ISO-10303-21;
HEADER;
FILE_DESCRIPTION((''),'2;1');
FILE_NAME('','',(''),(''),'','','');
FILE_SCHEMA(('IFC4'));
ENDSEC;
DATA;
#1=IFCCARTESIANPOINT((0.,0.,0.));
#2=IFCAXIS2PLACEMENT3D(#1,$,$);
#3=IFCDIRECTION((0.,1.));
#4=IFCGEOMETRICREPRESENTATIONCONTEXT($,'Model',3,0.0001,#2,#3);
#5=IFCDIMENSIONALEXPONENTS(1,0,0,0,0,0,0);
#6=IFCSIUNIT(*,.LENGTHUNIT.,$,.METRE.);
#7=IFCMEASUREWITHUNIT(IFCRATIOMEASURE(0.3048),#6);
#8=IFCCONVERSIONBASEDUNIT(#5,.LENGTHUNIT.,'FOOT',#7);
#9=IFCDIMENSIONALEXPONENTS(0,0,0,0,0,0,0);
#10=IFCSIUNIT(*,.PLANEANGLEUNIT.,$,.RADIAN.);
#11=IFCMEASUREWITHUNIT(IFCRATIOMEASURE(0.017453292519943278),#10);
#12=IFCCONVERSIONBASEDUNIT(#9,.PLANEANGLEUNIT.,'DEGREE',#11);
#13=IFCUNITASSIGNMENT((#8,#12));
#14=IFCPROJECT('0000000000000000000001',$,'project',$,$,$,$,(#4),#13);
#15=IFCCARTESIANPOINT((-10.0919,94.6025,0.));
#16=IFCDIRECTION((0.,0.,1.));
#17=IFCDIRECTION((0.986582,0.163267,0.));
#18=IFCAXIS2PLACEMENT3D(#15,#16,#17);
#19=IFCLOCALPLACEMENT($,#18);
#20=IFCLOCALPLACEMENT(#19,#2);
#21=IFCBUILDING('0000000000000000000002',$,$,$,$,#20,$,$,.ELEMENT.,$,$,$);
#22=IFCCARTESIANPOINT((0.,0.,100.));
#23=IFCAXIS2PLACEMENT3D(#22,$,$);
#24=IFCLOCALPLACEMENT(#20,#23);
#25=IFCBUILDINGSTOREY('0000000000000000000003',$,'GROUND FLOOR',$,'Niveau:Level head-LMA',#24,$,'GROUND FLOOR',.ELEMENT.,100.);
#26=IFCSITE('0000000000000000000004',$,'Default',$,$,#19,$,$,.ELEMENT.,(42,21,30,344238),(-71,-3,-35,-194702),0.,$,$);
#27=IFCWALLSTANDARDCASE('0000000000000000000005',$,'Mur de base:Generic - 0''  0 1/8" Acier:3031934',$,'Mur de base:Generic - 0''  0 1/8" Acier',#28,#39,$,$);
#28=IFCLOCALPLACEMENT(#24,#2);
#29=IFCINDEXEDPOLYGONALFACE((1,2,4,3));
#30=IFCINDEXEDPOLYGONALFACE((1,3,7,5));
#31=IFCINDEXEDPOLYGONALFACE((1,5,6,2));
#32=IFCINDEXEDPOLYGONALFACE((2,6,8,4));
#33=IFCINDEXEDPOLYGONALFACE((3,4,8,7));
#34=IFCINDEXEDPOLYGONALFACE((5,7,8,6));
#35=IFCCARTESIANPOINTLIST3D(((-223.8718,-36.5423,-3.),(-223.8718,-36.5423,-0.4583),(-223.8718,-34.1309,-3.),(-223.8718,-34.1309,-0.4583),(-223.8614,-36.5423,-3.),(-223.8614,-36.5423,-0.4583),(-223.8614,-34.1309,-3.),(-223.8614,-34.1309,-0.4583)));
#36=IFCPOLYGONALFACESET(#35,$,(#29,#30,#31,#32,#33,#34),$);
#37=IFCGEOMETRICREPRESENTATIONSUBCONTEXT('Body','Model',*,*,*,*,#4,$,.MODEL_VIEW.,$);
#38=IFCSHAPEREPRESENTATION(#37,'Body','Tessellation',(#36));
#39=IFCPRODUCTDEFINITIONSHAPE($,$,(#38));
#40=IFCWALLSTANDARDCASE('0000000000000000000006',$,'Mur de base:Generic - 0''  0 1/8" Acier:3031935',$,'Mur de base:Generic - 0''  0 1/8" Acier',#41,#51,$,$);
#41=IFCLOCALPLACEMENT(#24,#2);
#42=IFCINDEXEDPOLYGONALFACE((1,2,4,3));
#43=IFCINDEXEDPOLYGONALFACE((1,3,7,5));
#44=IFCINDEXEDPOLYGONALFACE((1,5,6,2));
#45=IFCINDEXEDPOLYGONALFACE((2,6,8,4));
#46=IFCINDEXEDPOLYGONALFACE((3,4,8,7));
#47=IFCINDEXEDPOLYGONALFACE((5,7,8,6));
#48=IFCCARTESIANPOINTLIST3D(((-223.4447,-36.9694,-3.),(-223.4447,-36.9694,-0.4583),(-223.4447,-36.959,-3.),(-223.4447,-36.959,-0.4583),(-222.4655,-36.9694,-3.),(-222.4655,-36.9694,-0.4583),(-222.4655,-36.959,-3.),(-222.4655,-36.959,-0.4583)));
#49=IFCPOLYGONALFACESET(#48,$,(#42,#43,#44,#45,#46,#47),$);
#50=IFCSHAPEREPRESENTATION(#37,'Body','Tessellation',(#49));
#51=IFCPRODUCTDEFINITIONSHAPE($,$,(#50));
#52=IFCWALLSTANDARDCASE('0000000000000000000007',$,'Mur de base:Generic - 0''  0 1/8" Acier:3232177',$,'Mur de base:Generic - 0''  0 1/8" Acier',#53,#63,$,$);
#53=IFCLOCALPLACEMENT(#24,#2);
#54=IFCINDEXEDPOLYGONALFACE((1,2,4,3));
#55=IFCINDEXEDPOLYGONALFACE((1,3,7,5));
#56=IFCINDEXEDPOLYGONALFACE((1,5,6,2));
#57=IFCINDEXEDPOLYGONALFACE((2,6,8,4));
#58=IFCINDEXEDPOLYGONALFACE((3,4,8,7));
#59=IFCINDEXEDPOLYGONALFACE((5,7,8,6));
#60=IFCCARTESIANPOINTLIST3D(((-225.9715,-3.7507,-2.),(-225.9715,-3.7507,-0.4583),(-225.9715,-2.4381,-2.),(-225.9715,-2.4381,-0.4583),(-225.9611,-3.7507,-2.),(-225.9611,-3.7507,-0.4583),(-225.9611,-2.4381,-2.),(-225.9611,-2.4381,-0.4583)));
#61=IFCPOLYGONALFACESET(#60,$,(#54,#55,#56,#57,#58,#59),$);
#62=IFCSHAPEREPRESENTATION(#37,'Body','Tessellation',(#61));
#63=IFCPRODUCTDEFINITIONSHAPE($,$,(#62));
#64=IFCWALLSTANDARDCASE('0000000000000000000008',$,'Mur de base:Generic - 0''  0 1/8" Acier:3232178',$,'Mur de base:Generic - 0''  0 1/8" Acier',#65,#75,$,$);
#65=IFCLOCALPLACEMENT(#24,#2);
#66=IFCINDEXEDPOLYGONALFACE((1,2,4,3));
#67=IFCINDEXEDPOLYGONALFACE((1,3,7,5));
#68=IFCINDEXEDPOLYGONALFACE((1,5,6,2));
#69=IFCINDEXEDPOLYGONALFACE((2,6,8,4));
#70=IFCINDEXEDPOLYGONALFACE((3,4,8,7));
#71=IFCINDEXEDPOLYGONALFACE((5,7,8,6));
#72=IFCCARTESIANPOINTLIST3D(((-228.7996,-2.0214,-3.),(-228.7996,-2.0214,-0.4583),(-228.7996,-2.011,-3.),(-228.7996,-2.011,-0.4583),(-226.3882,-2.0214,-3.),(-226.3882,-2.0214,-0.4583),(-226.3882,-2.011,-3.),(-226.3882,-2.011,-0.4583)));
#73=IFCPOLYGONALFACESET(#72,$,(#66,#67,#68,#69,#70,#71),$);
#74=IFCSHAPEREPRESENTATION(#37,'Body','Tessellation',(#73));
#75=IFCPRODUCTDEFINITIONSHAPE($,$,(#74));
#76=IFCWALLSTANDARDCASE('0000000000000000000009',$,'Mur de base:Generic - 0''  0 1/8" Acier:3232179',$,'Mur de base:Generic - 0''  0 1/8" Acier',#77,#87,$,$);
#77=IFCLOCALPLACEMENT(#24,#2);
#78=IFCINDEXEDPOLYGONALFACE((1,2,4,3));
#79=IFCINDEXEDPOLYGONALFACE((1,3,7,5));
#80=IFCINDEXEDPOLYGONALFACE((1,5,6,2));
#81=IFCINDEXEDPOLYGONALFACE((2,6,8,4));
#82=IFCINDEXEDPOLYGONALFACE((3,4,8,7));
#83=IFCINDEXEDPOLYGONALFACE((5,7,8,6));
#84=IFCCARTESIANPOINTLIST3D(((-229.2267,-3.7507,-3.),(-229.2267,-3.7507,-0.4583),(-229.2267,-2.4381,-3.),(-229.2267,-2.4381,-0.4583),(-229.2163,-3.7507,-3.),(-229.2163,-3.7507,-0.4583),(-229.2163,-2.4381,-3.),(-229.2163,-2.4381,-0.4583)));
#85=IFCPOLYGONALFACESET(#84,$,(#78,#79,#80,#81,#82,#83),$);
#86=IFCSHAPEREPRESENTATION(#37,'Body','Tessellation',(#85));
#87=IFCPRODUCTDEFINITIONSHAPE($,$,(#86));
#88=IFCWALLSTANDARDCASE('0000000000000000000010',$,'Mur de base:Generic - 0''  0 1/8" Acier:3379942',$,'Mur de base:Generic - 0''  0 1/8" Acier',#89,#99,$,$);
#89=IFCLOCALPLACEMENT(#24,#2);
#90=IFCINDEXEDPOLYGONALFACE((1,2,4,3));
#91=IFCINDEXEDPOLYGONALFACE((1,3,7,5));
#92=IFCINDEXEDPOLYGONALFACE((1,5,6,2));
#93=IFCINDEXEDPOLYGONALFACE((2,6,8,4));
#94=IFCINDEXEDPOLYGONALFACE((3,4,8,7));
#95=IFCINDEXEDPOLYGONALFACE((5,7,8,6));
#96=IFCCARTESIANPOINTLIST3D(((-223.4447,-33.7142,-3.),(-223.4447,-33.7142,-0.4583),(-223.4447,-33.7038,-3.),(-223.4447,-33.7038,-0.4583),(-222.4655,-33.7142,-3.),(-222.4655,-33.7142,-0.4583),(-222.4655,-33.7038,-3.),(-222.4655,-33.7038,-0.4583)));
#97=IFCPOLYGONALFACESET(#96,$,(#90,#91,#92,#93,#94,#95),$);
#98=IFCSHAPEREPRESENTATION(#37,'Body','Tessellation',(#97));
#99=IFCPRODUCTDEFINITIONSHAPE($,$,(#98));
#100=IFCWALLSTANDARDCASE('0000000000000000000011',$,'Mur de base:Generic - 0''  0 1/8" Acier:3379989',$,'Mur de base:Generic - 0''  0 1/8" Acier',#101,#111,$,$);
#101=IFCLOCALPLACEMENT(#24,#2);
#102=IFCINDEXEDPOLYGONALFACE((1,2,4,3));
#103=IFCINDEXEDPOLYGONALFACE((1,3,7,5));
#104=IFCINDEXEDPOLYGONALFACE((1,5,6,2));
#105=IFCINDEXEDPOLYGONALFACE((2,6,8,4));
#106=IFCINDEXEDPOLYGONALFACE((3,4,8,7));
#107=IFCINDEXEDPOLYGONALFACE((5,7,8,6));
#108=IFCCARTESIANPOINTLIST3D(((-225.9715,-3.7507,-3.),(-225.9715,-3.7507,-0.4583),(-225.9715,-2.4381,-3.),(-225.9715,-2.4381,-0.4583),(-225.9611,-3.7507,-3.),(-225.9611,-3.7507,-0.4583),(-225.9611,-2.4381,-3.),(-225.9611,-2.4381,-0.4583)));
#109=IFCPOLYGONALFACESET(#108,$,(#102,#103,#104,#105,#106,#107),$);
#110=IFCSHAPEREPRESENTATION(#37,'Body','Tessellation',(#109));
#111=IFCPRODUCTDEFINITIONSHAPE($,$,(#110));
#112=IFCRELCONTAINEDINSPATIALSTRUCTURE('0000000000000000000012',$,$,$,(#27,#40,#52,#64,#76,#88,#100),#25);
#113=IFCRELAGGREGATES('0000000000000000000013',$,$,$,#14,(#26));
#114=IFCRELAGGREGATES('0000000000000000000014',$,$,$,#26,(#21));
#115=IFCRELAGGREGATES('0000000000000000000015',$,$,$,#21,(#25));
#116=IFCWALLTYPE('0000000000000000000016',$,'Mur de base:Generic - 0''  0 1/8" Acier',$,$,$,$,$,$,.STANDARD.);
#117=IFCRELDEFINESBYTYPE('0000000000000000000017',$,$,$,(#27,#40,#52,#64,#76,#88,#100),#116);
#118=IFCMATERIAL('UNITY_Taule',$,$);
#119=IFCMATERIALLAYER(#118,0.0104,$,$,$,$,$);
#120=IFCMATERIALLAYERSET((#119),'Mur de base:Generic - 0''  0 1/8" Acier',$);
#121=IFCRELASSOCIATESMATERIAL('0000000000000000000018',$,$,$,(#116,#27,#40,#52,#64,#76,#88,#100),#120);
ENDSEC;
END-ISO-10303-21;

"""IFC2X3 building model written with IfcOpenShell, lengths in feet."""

from ifc_helpers import new_model, entity, si_unit, converted_unit, direction, frame, frame_2d, origin, place, context, subcontext, project, spatial, rectangle, extrude, material, layer, layer_set, layer_usage, type_object, element, save


model = new_model("IFC2X3")

# Units and contexts
model_context = context("Model", 3, precision=0.0001, world=origin(), true_north=direction((0.0, 1.0)))
body_context = subcontext(model_context, "Body", "Model", "MODEL_VIEW")
ifc_project = project(units=[converted_unit("LENGTHUNIT", "FOOT", entity("IfcRatioMeasure", 0.3048), si_unit("LENGTHUNIT", "METRE"), dimensions=[1, 0, 0, 0, 0, 0, 0]), converted_unit("PLANEANGLEUNIT", "DEGREE", entity("IfcRatioMeasure", 0.017453292519943278), si_unit("PLANEANGLEUNIT", "RADIAN"), dimensions=[0, 0, 0, 0, 0, 0, 0])], contexts=[model_context])

# Site, building, storey
site_placement = place(None, frame((-10.0919, 94.6025, 0.0), z_axis=(0.0, 0.0, 1.0), x_axis=(0.986582, 0.163267, 0.0)))
site = spatial("IfcSite", under=ifc_project, at=site_placement, Name="Default", CompositionType="ELEMENT", RefLatitude=(42, 21, 30, 344238), RefLongitude=(-71, -3, -35, -194702), RefElevation=0.0)
building_placement = place(site_placement, origin())
building = spatial("IfcBuilding", under=site, at=building_placement, CompositionType="ELEMENT")
storey_placement = place(building_placement, frame((0.0, 0.0, 100.0)))
storey = spatial("IfcBuildingStorey", under=building, at=storey_placement, Name="GROUND FLOOR", ObjectType="Niveau:Level head-LMA", LongName="GROUND FLOOR", CompositionType="ELEMENT", Elevation=100.0)

# Walls
ifc_material_1 = material(Name="UNITY_Taule")
ifc_layer = layer(ifc_material_1, 0.0104)
ifc_layer_set = layer_set([ifc_layer], Name="Mur de base:Generic - 0'  0 1/8\" Acier")
wall_type = type_object("IfcWallType", Name="Mur de base:Generic - 0'  0 1/8\" Acier", PredefinedType="STANDARD", material=ifc_layer_set)
ifc_layer_usage_1 = layer_usage(ifc_layer_set, "AXIS2", "NEGATIVE", 0.0052)
wall_1_placement = place(storey_placement, frame((-223.8666, -34.1309, -3.0), z_axis=(0.0, 0.0, 1.0), x_axis=(0.0, -1.0, 0.0)))
element("IfcWallStandardCase", 1, at=wall_1_placement, inside=storey, type_object=wall_type, material=ifc_layer_usage_1, Name="Mur de base:Generic - 0'  0 1/8\" Acier:3031934", ObjectType="Mur de base:Generic - 0'  0 1/8\" Acier", context=body_context, shape_type="SweptSolid", body=[
    extrude(rectangle(XDim=2.4115, YDim=0.0104, at=frame_2d((1.2057, 0.0), x_axis=(-1.0, 0.0))), origin(), (0.0, 0.0, 1.0), 2.5417),
])
ifc_layer_usage_2 = layer_usage(ifc_layer_set, "AXIS2", "POSITIVE", -0.0052)
wall_2_placement = place(storey_placement, frame((-222.4655, -36.9642, -3.0), z_axis=(0.0, 0.0, 1.0), x_axis=(-1.0, 0.0, 0.0)))
element("IfcWallStandardCase", 2, at=wall_2_placement, inside=storey, type_object=wall_type, material=ifc_layer_usage_2, Name="Mur de base:Generic - 0'  0 1/8\" Acier:3031935", ObjectType="Mur de base:Generic - 0'  0 1/8\" Acier", context=body_context, shape_type="SweptSolid", body=[
    extrude(rectangle(XDim=0.9792, YDim=0.0104, at=frame_2d((0.4896, 0.0), x_axis=(-1.0, 0.0))), origin(), (0.0, 0.0, 1.0), 2.5417),
])
ifc_layer_usage_3 = layer_usage(ifc_layer_set, "AXIS2", "NEGATIVE", 0.0052)
wall_3_placement = place(storey_placement, frame((-225.9663, -3.7507, -2.0), z_axis=(0.0, 0.0, 1.0), x_axis=(0.0, 1.0, 0.0)))
element("IfcWallStandardCase", 3, at=wall_3_placement, inside=storey, type_object=wall_type, material=ifc_layer_usage_3, Name="Mur de base:Generic - 0'  0 1/8\" Acier:3232177", ObjectType="Mur de base:Generic - 0'  0 1/8\" Acier", context=body_context, shape_type="SweptSolid", body=[
    extrude(rectangle(XDim=1.3126, YDim=0.0104, at=frame_2d((0.6563, 0.0), x_axis=(-1.0, 0.0))), origin(), (0.0, 0.0, 1.0), 1.5417),
])
ifc_layer_usage_4 = layer_usage(ifc_layer_set, "AXIS2", "NEGATIVE", 0.0052)
wall_4_placement = place(storey_placement, frame((-226.3882, -2.0162, -3.0), z_axis=(0.0, 0.0, 1.0), x_axis=(-1.0, 0.0, 0.0)))
element("IfcWallStandardCase", 4, at=wall_4_placement, inside=storey, type_object=wall_type, material=ifc_layer_usage_4, Name="Mur de base:Generic - 0'  0 1/8\" Acier:3232178", ObjectType="Mur de base:Generic - 0'  0 1/8\" Acier", context=body_context, shape_type="SweptSolid", body=[
    extrude(rectangle(XDim=2.4115, YDim=0.0104, at=frame_2d((1.2057, 0.0), x_axis=(-1.0, 0.0))), origin(), (0.0, 0.0, 1.0), 2.5417),
])
ifc_layer_usage_5 = layer_usage(ifc_layer_set, "AXIS2", "POSITIVE", -0.0052)
wall_5_placement = place(storey_placement, frame((-229.2215, -3.7507, -3.0), z_axis=(0.0, 0.0, 1.0), x_axis=(0.0, 1.0, 0.0)))
element("IfcWallStandardCase", 5, at=wall_5_placement, inside=storey, type_object=wall_type, material=ifc_layer_usage_5, Name="Mur de base:Generic - 0'  0 1/8\" Acier:3232179", ObjectType="Mur de base:Generic - 0'  0 1/8\" Acier", context=body_context, shape_type="SweptSolid", body=[
    extrude(rectangle(XDim=1.3126, YDim=0.0104, at=frame_2d((0.6563, 0.0), x_axis=(-1.0, 0.0))), origin(), (0.0, 0.0, 1.0), 2.5417),
])
ifc_layer_usage_6 = layer_usage(ifc_layer_set, "AXIS2", "NEGATIVE", 0.0052)
wall_6_placement = place(storey_placement, frame((-222.4655, -33.709, -3.0), z_axis=(0.0, 0.0, 1.0), x_axis=(-1.0, 0.0, 0.0)))
element("IfcWallStandardCase", 6, at=wall_6_placement, inside=storey, type_object=wall_type, material=ifc_layer_usage_6, Name="Mur de base:Generic - 0'  0 1/8\" Acier:3379942", ObjectType="Mur de base:Generic - 0'  0 1/8\" Acier", context=body_context, shape_type="SweptSolid", body=[
    extrude(rectangle(XDim=0.9792, YDim=0.0104, at=frame_2d((0.4896, 0.0), x_axis=(-1.0, 0.0))), origin(), (0.0, 0.0, 1.0), 2.5417),
])
ifc_layer_usage_7 = layer_usage(ifc_layer_set, "AXIS2", "NEGATIVE", 0.0052)
wall_7_placement = place(storey_placement, frame((-225.9663, -3.7507, -3.0), z_axis=(0.0, 0.0, 1.0), x_axis=(0.0, 1.0, 0.0)))
element("IfcWallStandardCase", 7, at=wall_7_placement, inside=storey, type_object=wall_type, material=ifc_layer_usage_7, Name="Mur de base:Generic - 0'  0 1/8\" Acier:3379989", ObjectType="Mur de base:Generic - 0'  0 1/8\" Acier", context=body_context, shape_type="SweptSolid", body=[
    extrude(rectangle(XDim=1.3126, YDim=0.0104, at=frame_2d((0.6563, 0.0), x_axis=(-1.0, 0.0))), origin(), (0.0, 0.0, 1.0), 2.5417),
])

save(model, "model.ifc")
